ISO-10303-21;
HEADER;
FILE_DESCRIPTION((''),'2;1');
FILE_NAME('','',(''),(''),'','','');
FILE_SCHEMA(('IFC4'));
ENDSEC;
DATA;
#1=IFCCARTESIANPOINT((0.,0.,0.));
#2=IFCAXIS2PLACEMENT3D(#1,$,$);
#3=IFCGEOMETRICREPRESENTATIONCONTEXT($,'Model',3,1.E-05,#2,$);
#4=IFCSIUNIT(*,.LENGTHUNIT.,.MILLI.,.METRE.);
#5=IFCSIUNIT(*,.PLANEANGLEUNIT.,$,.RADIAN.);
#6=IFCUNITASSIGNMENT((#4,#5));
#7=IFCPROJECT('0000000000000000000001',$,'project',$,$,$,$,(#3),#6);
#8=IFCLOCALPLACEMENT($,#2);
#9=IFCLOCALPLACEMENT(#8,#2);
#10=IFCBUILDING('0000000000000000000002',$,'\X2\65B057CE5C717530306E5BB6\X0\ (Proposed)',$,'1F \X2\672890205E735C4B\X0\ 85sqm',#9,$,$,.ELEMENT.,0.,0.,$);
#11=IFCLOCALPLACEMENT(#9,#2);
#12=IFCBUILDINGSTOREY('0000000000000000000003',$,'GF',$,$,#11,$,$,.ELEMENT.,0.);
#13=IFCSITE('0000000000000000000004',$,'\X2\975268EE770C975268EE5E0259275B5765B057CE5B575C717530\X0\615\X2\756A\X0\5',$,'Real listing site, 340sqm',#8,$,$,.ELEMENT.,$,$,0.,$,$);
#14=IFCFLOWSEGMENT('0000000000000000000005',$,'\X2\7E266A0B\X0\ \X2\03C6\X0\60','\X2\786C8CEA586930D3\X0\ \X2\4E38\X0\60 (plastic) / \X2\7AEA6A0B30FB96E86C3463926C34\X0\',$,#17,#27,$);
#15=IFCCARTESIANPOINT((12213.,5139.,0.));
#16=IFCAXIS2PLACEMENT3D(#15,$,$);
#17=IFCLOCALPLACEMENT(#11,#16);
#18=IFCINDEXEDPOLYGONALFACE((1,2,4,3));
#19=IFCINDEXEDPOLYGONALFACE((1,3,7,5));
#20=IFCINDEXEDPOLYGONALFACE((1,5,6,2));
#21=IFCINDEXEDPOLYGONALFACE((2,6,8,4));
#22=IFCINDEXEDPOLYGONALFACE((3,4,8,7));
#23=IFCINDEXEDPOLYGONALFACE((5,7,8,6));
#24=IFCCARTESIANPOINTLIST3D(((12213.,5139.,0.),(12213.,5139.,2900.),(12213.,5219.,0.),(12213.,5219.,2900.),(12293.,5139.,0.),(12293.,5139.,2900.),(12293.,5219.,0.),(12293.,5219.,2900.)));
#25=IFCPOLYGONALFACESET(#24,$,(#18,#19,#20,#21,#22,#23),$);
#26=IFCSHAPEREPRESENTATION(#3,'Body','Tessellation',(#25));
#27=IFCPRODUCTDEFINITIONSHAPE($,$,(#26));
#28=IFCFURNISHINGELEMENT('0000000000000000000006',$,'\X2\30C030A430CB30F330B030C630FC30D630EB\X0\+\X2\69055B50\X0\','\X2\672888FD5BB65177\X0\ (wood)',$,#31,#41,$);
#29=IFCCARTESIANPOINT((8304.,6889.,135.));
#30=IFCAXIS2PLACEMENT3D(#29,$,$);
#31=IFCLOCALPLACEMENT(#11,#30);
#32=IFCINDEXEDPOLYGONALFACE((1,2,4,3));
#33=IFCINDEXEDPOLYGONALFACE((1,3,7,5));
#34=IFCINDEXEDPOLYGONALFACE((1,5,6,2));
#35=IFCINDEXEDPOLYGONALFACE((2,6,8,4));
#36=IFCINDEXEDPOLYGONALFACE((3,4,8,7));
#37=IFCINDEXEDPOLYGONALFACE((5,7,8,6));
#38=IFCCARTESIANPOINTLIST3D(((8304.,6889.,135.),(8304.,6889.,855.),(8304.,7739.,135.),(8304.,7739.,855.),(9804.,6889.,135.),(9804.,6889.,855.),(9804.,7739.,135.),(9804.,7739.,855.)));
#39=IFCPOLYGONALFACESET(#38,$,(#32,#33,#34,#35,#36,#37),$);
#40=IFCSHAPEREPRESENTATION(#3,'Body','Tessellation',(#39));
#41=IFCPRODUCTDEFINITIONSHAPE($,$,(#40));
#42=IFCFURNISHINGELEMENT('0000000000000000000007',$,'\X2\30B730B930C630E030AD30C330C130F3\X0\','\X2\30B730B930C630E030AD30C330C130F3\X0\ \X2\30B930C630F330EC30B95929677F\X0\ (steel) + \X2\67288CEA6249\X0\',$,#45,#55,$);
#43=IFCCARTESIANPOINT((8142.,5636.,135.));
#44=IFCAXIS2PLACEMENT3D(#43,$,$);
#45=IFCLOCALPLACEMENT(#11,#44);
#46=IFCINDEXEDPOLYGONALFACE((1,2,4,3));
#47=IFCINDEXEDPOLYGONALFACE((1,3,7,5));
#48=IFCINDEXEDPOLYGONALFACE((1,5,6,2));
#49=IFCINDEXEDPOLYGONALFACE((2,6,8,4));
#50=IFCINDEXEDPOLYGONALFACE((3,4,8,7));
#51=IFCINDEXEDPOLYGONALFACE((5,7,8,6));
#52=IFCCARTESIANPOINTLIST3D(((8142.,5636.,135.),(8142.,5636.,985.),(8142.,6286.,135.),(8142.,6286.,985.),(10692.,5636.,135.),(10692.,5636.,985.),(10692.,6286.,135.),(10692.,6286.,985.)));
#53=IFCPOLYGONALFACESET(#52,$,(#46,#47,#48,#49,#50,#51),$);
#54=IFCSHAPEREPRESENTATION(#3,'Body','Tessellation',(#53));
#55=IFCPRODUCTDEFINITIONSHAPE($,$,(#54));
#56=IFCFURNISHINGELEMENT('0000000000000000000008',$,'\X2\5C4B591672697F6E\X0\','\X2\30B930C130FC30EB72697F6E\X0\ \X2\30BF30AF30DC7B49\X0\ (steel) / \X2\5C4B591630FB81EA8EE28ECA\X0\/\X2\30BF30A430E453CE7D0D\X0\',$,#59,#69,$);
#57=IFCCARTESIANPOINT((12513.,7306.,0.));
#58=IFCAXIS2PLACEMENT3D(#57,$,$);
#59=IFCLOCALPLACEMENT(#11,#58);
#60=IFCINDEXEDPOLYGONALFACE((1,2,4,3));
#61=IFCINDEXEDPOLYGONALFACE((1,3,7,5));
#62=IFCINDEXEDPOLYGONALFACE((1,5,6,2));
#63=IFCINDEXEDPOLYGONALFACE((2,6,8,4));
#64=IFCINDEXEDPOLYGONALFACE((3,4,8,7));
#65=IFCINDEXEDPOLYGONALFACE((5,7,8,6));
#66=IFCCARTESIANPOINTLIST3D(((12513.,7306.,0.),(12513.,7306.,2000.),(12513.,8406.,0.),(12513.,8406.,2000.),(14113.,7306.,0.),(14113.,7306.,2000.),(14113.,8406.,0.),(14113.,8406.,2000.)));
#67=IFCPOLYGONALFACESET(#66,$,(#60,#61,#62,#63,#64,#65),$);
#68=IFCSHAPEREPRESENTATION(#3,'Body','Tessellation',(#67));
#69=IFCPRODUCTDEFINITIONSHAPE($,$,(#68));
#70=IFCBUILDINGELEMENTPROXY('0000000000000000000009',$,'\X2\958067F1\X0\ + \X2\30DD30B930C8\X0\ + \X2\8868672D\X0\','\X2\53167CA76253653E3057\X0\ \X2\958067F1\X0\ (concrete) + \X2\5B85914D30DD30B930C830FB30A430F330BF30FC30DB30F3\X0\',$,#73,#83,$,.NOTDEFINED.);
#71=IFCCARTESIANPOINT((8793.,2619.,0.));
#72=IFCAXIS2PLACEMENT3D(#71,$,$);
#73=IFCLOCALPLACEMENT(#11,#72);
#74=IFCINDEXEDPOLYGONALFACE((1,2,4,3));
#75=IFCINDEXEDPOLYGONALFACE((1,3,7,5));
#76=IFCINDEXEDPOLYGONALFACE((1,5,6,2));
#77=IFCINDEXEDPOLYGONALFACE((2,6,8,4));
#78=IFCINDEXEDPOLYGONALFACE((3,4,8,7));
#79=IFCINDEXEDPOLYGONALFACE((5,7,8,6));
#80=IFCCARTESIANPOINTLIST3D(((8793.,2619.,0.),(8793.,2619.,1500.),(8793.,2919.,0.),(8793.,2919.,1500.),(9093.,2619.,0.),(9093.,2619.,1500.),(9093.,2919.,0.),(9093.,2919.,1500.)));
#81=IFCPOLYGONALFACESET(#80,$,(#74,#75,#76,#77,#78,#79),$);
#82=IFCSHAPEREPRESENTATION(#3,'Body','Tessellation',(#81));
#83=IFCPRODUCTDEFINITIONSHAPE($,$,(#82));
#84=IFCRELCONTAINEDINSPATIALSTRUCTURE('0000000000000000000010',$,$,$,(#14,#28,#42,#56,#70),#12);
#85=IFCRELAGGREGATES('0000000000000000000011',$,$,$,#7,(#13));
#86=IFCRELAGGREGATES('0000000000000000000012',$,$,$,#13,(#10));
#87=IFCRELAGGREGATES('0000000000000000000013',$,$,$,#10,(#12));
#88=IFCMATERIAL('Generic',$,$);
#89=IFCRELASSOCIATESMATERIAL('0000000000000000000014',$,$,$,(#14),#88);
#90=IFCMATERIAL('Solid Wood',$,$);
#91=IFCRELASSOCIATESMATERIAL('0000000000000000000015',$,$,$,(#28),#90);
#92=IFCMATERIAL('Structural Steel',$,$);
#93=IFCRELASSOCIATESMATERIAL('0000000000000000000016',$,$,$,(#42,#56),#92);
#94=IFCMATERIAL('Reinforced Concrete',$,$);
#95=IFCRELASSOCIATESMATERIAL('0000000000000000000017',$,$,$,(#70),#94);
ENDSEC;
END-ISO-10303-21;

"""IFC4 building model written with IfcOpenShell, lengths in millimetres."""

from ifc_helpers import new_model, si_unit, frame, frame_2d, origin, place, context, project, spatial, rectangle, extrude, material, element, save


model = new_model("IFC4")

# Units and contexts
model_context = context("Model", 3, precision=1e-05, world=origin())
ifc_project = project(units=[si_unit("LENGTHUNIT", "METRE", prefix="MILLI"), si_unit("PLANEANGLEUNIT", "RADIAN")], contexts=[model_context])

# Site, building, storey
site_placement = place(None, origin())
site = spatial("IfcSite", under=ifc_project, at=site_placement, Name="青森県青森市大字新城字山田615番5", ObjectType="Real listing site, 340sqm", CompositionType="ELEMENT", RefElevation=0.0)
building_placement = place(site_placement, origin())
building = spatial("IfcBuilding", under=site, at=building_placement, Name="新城山田の家 (Proposed)", ObjectType="1F 木造平屋 85sqm", CompositionType="ELEMENT", ElevationOfRefHeight=0.0, ElevationOfTerrain=0.0)
storey_placement = place(building_placement, origin())
storey = spatial("IfcBuildingStorey", under=building, at=storey_placement, Name="GF", CompositionType="ELEMENT", Elevation=0.0)

# Shared definitions
ifc_material_1 = material(Name="Solid Wood")

# Shared definitions
ifc_material_2 = material(Name="Structural Steel")

# Shared definitions
ifc_material_3 = material(Name="Reinforced Concrete")

# Shared definitions
ifc_material_4 = material(Name="Generic")

# Flow segment
flow_segment_placement = place(storey_placement, frame((12213.0, 5139.0, 0.0)))
element("IfcFlowSegment", 1, at=flow_segment_placement, inside=storey, material=ifc_material_4, Name="縦樋 φ60", Description="硬質塩ビ 丸60 (plastic) / 竪樋・雨水排水", context=model_context, shape_type="SweptSolid", body=[
    extrude(rectangle(XDim=80.0, YDim=80.0, at=frame_2d((40.0, 40.0))), frame((12213.0, 5139.0, 0.0)), (0.0, 0.0, 1.0), 2900.0),
])

# Furnishing elements
furnishing_1_placement = place(storey_placement, frame((8304.0, 6889.0, 135.0)))
element("IfcFurnishingElement", 2, at=furnishing_1_placement, inside=storey, material=ifc_material_1, Name="ダイニングテーブル+椅子", Description="木製家具 (wood)", context=model_context, shape_type="SweptSolid", body=[
    extrude(rectangle(XDim=1500.0, YDim=850.0, at=frame_2d((750.0, 425.0))), frame((8304.0, 6889.0, 135.0)), (0.0, 0.0, 1.0), 720.0),
])
furnishing_2_placement = place(storey_placement, frame((8142.0, 5636.0, 135.0)))
element("IfcFurnishingElement", 3, at=furnishing_2_placement, inside=storey, material=ifc_material_2, Name="システムキッチン", Description="システムキッチン ステンレス天板 (steel) + 木質扉", context=model_context, shape_type="SweptSolid", body=[
    extrude(rectangle(XDim=2550.0, YDim=650.0, at=frame_2d((1275.0, 325.0))), frame((8142.0, 5636.0, 135.0)), (0.0, 0.0, 1.0), 850.0),
])
furnishing_3_placement = place(storey_placement, frame((12513.0, 7306.0, 0.0)))
element("IfcFurnishingElement", 4, at=furnishing_3_placement, inside=storey, material=ifc_material_2, Name="屋外物置", Description="スチール物置 タクボ等 (steel) / 屋外・自転車/タイヤ収納", context=model_context, shape_type="SweptSolid", body=[
    extrude(rectangle(XDim=1600.0, YDim=1100.0, at=frame_2d((800.0, 550.0))), frame((12513.0, 7306.0, 0.0)), (0.0, 0.0, 1.0), 2000.0),
])

# Building element proxy
proxy_placement = place(storey_placement, frame((8793.0, 2619.0, 0.0)))
element("IfcBuildingElementProxy", 5, at=proxy_placement, inside=storey, material=ifc_material_3, Name="門柱 + ポスト + 表札", Description="化粧打放し 門柱 (concrete) + 宅配ポスト・インターホン", PredefinedType="NOTDEFINED", context=model_context, shape_type="SweptSolid", body=[
    extrude(rectangle(XDim=300.0, YDim=300.0, at=frame_2d((150.0, 150.0))), frame((8793.0, 2619.0, 0.0)), (0.0, 0.0, 1.0), 1500.0),
])

save(model, "model.ifc")
